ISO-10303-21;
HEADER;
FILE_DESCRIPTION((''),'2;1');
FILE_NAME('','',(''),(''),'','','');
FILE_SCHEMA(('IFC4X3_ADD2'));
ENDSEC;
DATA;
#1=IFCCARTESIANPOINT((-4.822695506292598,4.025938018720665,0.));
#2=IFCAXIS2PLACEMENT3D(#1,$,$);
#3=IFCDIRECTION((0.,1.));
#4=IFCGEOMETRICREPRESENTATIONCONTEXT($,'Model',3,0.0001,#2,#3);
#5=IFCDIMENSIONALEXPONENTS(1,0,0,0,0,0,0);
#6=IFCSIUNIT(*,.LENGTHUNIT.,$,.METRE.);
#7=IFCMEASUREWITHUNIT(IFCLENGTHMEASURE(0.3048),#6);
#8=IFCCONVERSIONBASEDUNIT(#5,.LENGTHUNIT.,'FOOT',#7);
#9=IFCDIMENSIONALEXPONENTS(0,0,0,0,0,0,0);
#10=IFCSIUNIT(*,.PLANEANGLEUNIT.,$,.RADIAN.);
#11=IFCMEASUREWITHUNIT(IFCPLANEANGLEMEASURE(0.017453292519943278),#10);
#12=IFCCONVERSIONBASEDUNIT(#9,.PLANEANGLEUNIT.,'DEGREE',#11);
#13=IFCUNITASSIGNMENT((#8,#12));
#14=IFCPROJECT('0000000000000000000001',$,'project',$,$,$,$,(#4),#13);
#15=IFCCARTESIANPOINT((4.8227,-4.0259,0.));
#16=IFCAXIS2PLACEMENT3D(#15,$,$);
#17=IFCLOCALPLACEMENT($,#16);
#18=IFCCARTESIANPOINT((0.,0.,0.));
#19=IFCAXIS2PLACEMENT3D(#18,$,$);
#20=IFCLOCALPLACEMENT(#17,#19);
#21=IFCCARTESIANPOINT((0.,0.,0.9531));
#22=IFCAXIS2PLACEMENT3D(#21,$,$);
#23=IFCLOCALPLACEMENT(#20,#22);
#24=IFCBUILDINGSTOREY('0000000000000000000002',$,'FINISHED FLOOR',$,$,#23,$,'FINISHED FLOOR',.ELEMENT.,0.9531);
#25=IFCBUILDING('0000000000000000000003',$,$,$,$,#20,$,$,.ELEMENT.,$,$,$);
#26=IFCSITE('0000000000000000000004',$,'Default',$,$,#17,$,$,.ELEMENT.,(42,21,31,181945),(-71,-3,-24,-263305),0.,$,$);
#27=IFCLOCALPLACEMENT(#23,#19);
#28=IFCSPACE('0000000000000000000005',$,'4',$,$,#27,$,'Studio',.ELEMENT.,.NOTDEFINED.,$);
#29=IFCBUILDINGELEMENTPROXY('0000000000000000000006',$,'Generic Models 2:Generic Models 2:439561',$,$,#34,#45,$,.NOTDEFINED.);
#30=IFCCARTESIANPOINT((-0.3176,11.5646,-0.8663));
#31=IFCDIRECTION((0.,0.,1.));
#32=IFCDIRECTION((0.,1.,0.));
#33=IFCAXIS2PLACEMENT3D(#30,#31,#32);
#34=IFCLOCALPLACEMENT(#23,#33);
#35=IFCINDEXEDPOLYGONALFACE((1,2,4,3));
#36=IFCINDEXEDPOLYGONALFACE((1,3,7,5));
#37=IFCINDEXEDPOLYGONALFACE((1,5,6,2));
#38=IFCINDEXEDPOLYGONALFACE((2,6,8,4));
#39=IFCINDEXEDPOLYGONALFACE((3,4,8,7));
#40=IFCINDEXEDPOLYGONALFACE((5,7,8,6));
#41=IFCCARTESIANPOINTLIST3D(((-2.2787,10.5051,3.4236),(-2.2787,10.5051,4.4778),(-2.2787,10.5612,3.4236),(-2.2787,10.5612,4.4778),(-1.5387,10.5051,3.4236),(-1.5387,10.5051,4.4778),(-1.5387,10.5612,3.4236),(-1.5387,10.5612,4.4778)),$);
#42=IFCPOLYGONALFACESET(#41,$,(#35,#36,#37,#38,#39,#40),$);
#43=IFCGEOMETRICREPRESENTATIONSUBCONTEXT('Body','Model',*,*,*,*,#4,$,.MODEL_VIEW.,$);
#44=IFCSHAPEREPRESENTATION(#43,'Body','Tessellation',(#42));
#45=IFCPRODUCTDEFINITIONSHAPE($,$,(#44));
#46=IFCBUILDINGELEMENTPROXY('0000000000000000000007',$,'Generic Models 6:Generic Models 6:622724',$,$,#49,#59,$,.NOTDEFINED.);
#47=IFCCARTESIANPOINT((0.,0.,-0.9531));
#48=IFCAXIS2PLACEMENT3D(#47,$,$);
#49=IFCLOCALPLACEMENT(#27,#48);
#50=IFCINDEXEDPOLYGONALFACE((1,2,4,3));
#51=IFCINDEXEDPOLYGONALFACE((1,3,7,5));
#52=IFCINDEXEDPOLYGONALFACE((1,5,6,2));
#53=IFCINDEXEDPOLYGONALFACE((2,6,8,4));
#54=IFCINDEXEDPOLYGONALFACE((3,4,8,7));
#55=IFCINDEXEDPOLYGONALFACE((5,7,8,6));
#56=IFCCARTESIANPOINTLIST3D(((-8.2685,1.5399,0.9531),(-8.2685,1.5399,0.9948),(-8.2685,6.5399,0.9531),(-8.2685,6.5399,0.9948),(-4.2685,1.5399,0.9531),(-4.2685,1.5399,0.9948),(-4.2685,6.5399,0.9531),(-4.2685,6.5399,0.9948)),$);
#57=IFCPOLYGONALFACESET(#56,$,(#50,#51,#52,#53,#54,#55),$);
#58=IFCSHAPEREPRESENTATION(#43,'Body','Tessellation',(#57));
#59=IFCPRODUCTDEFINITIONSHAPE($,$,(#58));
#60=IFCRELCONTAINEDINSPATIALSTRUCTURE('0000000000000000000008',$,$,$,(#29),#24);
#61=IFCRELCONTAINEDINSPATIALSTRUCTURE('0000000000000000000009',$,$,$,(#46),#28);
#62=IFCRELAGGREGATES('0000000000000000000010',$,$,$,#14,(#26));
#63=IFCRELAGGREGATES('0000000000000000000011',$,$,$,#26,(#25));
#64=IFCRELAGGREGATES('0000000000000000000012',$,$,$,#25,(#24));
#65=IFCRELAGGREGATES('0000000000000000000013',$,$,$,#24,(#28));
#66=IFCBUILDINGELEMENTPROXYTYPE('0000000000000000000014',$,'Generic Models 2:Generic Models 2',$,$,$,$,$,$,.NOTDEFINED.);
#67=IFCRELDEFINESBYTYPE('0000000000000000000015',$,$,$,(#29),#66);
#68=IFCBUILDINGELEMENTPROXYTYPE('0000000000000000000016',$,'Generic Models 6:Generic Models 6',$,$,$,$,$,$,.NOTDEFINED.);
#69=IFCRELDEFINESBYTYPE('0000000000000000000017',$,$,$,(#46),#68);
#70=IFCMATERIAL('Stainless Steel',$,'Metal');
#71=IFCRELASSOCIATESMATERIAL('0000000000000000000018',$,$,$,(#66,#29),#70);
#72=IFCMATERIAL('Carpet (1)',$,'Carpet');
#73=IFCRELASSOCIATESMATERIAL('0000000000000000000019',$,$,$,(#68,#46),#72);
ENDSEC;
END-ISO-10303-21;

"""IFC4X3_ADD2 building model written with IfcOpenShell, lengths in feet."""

from ifc_helpers import new_model, entity, si_unit, converted_unit, direction, frame, frame_2d, origin, place, context, subcontext, project, spatial, rectangle, extrude, source, transform, mapped, material, type_object, type_shapes, element, save


model = new_model("IFC4X3_ADD2")

# Units and contexts
model_context = context("Model", 3, precision=0.0001, world=frame((-4.822695506292598, 4.025938018720665, 0.0)), true_north=direction((0.0, 1.0)))
body_context = subcontext(model_context, "Body", "Model", "MODEL_VIEW")
ifc_project = project(units=[converted_unit("LENGTHUNIT", "FOOT", entity("IfcLengthMeasure", 0.3048), si_unit("LENGTHUNIT", "METRE"), dimensions=[1, 0, 0, 0, 0, 0, 0]), converted_unit("PLANEANGLEUNIT", "DEGREE", entity("IfcPlaneAngleMeasure", 0.017453292519943278), si_unit("PLANEANGLEUNIT", "RADIAN"), dimensions=[0, 0, 0, 0, 0, 0, 0])], contexts=[model_context])

# Site, building, storey
site_placement = place(None, frame((4.8227, -4.0259, 0.0)))
site = spatial("IfcSite", under=ifc_project, at=site_placement, Name="Default", CompositionType="ELEMENT", RefLatitude=(42, 21, 31, 181945), RefLongitude=(-71, -3, -24, -263305), RefElevation=0.0)
building_placement = place(site_placement, origin())
building = spatial("IfcBuilding", under=site, at=building_placement, CompositionType="ELEMENT")
storey_placement = place(building_placement, frame((0.0, 0.0, 0.9531)))
storey = spatial("IfcBuildingStorey", under=building, at=storey_placement, Name="FINISHED FLOOR", LongName="FINISHED FLOOR", CompositionType="ELEMENT", Elevation=0.9531)

# Shared definitions
space_placement = place(storey_placement, origin())
space = spatial("IfcSpace", under=storey, at=space_placement, Name="4", LongName="Studio", CompositionType="ELEMENT", PredefinedType="NOTDEFINED")

# Building element proxies
ifc_material_1 = material(Name="Stainless Steel", Category="Metal")
building_element_proxy_type_1 = type_object("IfcBuildingElementProxyType", Name="Generic Models 2:Generic Models 2", PredefinedType="NOTDEFINED", material=ifc_material_1)
shared_shape_1 = source(origin(), body_context, "Body", "SweptSolid", [
    extrude(rectangle(XDim=0.0561, YDim=0.74, at=frame_2d((0.0, 0.0), x_axis=(1.0, 0.0))), frame((-1.9087, 10.5331, 3.4236), z_axis=(0.0, 0.0, 1.0), x_axis=(0.0, -1.0, 0.0)), (0.0, 0.0, 1.0), 1.0542),
])
type_shapes(building_element_proxy_type_1, [shared_shape_1])
proxy_1_placement = place(storey_placement, frame((-0.3176, 11.5646, -0.8663), z_axis=(0.0, 0.0, 1.0), x_axis=(0.0, 1.0, 0.0)))
element("IfcBuildingElementProxy", 1, at=proxy_1_placement, inside=storey, type_object=building_element_proxy_type_1, material=ifc_material_1, Name="Generic Models 2:Generic Models 2:439561", PredefinedType="NOTDEFINED", context=body_context, shape_type="MappedRepresentation", body=[
    mapped(shared_shape_1, transform((0.0, 0.0, 0.0), scale=1.0)),
])
ifc_material_2 = material(Name="Carpet (1)", Category="Carpet")
building_element_proxy_type_2 = type_object("IfcBuildingElementProxyType", Name="Generic Models 6:Generic Models 6", PredefinedType="NOTDEFINED", material=ifc_material_2)
shared_shape_2 = source(origin(), body_context, "Body", "SweptSolid", [
    extrude(rectangle(XDim=4.0, YDim=5.0, at=frame_2d((0.0, 0.0), x_axis=(1.0, 0.0))), frame((-6.2685, 4.0399, 0.9531), z_axis=(0.0, 0.0, 1.0), x_axis=(-1.0, 0.0, 0.0)), (0.0, 0.0, 1.0), 0.0417),
])
type_shapes(building_element_proxy_type_2, [shared_shape_2])
proxy_2_placement = place(space_placement, frame((0.0, 0.0, -0.9531)))
element("IfcBuildingElementProxy", 2, at=proxy_2_placement, inside=space, type_object=building_element_proxy_type_2, material=ifc_material_2, Name="Generic Models 6:Generic Models 6:622724", PredefinedType="NOTDEFINED", context=body_context, shape_type="MappedRepresentation", body=[
    mapped(shared_shape_2, transform((0.0, 0.0, 0.0), scale=1.0)),
])

save(model, "model.ifc")
